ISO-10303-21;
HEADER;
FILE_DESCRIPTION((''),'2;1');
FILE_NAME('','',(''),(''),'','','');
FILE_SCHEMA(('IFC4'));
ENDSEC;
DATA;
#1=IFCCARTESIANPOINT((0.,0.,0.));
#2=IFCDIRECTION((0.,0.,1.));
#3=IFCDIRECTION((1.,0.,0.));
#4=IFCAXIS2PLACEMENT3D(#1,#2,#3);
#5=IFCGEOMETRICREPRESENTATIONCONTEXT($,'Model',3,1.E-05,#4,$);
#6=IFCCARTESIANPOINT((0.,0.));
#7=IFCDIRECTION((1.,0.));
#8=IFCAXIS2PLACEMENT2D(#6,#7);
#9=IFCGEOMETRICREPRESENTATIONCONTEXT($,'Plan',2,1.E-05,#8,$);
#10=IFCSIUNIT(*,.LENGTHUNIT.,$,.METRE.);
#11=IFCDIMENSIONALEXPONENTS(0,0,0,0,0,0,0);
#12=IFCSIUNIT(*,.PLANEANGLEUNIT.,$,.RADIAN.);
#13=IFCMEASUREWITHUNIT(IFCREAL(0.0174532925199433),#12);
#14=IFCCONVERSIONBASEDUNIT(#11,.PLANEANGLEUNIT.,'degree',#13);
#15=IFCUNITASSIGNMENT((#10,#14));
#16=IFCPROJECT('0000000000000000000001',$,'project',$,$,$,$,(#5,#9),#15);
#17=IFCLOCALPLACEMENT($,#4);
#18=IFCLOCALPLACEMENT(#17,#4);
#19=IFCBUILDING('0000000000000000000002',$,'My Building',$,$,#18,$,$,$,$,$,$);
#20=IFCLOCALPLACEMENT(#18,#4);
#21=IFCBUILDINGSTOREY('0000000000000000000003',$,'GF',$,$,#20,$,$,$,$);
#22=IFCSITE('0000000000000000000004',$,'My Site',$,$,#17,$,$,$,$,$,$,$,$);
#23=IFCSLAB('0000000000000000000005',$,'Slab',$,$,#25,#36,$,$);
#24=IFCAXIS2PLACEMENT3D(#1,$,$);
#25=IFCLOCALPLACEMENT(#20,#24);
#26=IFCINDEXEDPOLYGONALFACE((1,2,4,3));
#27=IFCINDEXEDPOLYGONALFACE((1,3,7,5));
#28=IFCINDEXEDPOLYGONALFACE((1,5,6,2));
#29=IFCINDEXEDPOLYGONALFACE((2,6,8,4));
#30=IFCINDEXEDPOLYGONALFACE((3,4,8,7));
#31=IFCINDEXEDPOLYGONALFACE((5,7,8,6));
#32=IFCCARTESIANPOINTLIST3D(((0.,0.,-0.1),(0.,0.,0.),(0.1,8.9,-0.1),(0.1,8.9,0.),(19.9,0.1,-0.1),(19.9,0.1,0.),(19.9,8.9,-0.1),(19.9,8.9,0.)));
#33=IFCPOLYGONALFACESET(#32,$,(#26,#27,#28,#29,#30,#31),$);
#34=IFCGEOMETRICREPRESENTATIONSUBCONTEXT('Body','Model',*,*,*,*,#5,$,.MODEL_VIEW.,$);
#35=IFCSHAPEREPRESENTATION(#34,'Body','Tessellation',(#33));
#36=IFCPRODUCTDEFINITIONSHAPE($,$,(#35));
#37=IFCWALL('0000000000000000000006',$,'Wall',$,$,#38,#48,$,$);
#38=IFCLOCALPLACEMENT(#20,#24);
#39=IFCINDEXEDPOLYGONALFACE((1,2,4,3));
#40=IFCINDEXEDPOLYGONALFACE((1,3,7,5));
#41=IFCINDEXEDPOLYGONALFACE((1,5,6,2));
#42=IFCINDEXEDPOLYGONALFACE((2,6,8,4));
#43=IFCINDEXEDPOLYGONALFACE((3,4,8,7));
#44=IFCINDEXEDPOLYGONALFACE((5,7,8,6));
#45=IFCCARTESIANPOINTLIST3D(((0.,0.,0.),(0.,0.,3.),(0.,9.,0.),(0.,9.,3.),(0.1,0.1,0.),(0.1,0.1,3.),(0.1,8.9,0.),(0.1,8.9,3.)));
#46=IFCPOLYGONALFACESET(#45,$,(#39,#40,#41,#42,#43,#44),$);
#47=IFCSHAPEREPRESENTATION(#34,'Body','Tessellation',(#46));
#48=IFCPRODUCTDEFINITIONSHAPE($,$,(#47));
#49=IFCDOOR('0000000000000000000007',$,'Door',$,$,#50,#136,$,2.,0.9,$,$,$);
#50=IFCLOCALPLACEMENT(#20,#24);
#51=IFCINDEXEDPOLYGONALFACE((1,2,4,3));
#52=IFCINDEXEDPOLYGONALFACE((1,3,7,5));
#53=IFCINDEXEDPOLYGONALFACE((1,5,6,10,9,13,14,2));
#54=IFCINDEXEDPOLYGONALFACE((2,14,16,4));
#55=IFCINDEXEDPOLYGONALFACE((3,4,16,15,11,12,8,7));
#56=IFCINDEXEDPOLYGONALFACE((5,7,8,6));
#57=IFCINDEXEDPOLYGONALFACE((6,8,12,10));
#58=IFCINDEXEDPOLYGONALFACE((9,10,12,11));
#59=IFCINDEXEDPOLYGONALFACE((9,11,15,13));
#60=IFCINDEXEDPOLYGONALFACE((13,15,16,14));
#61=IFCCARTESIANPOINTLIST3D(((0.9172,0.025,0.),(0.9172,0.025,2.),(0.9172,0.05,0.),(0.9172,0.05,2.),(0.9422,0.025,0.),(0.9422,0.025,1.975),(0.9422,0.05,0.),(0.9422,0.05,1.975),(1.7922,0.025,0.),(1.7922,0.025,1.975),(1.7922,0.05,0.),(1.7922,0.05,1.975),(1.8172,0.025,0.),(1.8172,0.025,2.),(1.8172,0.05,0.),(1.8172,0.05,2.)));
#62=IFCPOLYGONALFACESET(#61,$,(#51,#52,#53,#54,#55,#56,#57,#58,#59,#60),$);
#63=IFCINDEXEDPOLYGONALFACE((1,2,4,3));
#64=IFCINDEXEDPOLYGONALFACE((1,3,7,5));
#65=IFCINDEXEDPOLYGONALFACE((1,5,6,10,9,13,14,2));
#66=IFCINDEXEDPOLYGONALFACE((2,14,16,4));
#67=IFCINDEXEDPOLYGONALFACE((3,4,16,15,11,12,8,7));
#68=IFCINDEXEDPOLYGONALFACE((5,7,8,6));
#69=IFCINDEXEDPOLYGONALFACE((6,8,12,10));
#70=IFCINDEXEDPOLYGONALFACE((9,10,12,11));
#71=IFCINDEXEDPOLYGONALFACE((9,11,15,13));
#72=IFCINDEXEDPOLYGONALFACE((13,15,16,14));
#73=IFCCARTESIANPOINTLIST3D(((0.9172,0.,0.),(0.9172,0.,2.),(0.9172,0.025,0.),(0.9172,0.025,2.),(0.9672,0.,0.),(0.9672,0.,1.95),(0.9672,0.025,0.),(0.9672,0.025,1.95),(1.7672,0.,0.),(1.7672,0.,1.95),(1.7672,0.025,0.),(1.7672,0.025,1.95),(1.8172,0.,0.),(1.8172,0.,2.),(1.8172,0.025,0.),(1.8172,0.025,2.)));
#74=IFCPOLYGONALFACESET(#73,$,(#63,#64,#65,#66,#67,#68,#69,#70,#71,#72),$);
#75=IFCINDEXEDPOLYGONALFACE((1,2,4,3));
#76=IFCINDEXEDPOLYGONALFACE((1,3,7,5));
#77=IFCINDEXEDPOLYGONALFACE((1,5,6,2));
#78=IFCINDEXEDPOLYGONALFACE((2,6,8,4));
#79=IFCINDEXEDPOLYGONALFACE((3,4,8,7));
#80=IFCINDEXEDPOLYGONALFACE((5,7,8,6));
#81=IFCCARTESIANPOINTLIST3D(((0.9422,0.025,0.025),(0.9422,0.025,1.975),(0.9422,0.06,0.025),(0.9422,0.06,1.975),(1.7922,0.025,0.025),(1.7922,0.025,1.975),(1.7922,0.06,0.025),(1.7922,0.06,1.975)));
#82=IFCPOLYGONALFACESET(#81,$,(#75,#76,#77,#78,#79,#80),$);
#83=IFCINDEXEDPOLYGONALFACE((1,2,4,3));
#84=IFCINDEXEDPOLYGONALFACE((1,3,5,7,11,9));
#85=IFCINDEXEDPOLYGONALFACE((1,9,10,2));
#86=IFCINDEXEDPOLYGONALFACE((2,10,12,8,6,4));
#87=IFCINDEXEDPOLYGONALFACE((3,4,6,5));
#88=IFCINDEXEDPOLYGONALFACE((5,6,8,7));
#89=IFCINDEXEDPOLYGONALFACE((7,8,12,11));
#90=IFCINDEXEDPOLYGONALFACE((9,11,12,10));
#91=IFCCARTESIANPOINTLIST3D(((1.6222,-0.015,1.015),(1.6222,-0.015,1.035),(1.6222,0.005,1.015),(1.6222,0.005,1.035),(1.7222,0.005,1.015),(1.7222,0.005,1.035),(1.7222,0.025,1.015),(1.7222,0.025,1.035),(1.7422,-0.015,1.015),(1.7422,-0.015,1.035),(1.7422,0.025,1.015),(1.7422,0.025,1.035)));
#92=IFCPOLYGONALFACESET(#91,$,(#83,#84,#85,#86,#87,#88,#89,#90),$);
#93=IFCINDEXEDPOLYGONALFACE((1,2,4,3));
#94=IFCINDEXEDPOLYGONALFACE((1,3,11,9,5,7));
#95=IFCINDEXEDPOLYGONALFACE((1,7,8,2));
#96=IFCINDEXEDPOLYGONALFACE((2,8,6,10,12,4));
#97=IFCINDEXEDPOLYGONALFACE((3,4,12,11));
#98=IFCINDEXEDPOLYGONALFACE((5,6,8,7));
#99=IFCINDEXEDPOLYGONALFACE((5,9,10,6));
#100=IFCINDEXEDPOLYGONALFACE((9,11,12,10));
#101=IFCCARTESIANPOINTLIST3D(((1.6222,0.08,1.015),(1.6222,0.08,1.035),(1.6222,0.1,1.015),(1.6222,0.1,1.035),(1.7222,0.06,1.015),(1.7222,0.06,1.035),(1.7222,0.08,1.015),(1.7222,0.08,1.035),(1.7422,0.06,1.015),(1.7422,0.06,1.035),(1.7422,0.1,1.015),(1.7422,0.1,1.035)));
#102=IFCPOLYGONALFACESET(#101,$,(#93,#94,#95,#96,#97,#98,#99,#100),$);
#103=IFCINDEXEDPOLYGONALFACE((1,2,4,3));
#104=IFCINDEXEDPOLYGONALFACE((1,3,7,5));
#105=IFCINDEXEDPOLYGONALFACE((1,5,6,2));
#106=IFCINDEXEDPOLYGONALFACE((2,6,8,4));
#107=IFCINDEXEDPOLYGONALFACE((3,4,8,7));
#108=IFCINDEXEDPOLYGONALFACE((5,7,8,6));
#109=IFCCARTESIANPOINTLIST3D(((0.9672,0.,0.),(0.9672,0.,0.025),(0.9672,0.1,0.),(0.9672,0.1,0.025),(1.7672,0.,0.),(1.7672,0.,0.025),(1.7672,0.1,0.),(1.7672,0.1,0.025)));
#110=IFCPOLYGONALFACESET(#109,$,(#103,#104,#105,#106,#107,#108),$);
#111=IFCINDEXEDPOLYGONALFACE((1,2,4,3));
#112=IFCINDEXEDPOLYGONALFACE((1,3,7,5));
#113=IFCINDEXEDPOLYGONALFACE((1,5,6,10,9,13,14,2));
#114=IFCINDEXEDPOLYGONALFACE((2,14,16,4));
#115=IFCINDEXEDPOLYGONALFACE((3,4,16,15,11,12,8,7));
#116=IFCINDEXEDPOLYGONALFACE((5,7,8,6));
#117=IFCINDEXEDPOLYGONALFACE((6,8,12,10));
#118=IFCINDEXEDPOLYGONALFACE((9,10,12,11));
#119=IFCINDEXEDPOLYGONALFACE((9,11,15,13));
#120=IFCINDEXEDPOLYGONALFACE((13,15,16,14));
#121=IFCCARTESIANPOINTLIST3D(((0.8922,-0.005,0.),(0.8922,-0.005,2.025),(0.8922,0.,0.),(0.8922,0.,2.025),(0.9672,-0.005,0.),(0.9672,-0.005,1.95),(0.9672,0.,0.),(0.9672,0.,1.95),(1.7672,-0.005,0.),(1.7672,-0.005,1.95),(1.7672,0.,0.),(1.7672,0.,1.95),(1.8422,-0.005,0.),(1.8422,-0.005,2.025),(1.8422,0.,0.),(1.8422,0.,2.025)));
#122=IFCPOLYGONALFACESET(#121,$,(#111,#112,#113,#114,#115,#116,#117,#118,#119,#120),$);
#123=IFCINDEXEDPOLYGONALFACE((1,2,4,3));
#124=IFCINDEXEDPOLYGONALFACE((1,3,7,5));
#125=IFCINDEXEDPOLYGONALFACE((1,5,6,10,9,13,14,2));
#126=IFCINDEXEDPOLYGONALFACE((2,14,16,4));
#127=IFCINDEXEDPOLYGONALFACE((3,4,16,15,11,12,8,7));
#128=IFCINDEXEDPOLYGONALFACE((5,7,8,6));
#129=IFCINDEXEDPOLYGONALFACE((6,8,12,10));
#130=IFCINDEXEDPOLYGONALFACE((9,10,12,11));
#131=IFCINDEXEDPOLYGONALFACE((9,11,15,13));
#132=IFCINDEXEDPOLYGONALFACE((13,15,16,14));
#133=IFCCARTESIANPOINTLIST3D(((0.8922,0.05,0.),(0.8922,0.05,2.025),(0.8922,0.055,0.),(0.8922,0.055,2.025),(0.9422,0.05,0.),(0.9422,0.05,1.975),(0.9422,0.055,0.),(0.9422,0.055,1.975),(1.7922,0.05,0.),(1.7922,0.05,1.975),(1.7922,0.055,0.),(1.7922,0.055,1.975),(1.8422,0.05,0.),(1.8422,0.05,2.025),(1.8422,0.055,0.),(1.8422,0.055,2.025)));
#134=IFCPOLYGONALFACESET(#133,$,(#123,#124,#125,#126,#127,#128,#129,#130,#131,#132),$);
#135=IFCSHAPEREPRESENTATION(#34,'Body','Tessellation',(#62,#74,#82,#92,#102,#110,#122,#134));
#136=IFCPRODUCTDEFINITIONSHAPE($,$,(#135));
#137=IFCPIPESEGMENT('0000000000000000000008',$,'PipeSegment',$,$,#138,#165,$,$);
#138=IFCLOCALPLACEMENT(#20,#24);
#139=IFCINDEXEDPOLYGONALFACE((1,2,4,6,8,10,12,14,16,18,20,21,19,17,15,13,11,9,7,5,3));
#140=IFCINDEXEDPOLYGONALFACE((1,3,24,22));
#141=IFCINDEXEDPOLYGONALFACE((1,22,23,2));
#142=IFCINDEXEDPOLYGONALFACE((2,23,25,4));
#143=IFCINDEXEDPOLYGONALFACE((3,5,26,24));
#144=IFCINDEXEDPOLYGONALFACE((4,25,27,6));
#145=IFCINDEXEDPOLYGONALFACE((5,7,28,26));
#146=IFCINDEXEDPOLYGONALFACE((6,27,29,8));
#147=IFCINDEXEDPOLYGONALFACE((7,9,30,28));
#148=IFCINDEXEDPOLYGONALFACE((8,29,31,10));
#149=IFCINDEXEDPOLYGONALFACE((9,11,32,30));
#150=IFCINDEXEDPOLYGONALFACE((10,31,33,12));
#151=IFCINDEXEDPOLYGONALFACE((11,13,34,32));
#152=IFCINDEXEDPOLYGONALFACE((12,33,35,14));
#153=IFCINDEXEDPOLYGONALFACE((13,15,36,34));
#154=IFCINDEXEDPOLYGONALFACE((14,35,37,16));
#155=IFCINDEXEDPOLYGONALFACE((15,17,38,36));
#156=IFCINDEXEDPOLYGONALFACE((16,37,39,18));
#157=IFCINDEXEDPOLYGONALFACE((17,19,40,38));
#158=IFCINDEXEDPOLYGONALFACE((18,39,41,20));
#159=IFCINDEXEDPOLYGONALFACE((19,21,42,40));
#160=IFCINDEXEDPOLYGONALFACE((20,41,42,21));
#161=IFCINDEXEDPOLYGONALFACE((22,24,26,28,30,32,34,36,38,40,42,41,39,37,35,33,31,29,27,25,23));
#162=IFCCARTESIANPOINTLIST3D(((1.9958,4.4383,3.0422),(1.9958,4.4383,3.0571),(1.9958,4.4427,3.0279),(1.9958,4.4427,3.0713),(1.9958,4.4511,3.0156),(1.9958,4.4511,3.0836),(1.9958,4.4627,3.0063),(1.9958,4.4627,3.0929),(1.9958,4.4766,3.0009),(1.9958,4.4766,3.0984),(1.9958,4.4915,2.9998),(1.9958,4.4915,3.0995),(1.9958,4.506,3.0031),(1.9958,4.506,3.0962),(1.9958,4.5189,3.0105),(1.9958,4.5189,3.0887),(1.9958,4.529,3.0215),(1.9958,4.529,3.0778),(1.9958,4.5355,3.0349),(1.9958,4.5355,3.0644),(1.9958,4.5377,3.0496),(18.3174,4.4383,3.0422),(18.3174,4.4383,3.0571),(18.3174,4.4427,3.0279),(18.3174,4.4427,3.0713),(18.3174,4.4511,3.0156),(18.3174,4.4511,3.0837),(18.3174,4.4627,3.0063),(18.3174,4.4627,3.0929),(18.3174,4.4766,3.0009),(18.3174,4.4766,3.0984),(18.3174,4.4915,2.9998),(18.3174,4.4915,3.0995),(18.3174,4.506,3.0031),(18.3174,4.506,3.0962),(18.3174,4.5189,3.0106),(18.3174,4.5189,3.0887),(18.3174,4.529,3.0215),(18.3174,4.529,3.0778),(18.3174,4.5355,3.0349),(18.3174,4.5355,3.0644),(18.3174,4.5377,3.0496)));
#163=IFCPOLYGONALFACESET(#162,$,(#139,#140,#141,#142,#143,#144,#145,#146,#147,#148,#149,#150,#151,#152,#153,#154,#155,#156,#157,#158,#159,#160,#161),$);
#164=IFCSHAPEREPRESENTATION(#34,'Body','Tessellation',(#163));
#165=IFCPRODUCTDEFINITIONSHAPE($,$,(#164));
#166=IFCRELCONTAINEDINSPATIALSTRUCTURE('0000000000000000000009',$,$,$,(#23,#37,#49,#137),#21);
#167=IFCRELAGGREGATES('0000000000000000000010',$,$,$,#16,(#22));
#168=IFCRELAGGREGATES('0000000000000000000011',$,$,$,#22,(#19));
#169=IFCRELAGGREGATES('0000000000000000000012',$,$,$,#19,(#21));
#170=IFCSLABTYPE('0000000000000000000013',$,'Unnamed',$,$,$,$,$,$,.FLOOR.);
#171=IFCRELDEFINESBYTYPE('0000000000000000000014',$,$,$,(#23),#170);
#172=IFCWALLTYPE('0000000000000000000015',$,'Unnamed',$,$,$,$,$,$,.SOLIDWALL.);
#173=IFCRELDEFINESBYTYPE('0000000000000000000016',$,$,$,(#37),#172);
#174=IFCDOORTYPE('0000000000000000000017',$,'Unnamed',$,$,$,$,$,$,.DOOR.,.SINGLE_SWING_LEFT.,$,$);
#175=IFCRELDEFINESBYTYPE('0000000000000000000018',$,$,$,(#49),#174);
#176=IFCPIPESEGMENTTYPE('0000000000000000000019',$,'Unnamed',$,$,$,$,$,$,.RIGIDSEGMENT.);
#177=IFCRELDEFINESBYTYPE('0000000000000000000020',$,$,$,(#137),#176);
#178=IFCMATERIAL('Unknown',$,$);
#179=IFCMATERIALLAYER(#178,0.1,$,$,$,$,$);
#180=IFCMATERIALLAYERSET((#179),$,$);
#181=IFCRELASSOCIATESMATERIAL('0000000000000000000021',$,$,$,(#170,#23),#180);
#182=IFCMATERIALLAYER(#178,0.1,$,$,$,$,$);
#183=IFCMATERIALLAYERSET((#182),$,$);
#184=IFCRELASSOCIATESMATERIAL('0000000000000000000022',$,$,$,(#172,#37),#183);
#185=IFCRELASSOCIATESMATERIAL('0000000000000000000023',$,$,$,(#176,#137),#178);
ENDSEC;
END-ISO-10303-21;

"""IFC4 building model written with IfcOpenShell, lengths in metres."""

from ifc_helpers import new_model, entity, si_unit, converted_unit, frame, origin_with_axes, origin_2d_with_axis, place, context, subcontext, project, spatial, line, indexed_curve, circle, outline, extrude, shape, source, transform, mapped, material, layer, layer_set, layer_usage, material_profile, profile_set, profile_usage, type_object, type_shapes, element, save


model = new_model("IFC4")

# Units and contexts
model_context = context("Model", 3, precision=1e-05, world=origin_with_axes())
plan_context = context("Plan", 2, precision=1e-05, world=origin_2d_with_axis())
body_context_1 = subcontext(model_context, "Body", "Model", "MODEL_VIEW")
body_context_2 = subcontext(plan_context, "Body", "Plan", "PLAN_VIEW")
ifc_project = project(units=[si_unit("LENGTHUNIT", "METRE"), converted_unit("PLANEANGLEUNIT", "degree", entity("IfcReal", 0.0174532925199433), si_unit("PLANEANGLEUNIT", "RADIAN"), dimensions=[0, 0, 0, 0, 0, 0, 0])], contexts=[model_context, plan_context])

# Site, building, storey
site_placement = place(None, origin_with_axes())
site = spatial("IfcSite", under=ifc_project, at=site_placement, Name="My Site")
building_placement = place(site_placement, origin_with_axes())
building = spatial("IfcBuilding", under=site, at=building_placement, Name="My Building")
storey_placement = place(building_placement, origin_with_axes())
storey = spatial("IfcBuildingStorey", under=building, at=storey_placement, Name="GF")

# Slab
ifc_material = material(Name="Unknown")
ifc_layer_1 = layer(ifc_material, 0.1)
ifc_layer_set_1 = layer_set([ifc_layer_1])
ifc_layer_usage_1 = layer_usage(ifc_layer_set_1, "AXIS3", "POSITIVE", -0.1)
slab_type = type_object("IfcSlabType", Name="Unnamed", PredefinedType="FLOOR", material=ifc_layer_set_1)
slab_placement = place(storey_placement, frame((0.1, 8.9, 0.0), z_axis=(0.0, 0.0, 1.0), x_axis=(1.0, 0.0, 0.0)))
element("IfcSlab", 1, at=slab_placement, inside=storey, type_object=slab_type, material=ifc_layer_usage_1, Name="Slab", context=body_context_1, shape_type="SweptSolid", body=[
    extrude(outline(indexed_curve([(0.0, 0.0), (19.8, 0.0), (19.8, -8.8), (-0.1, -8.9), (0.0, 0.0)])), frame((0.0, 0.0, -0.1), z_axis=(0.0, 0.0, 1.0), x_axis=(1.0, 0.0, 0.0)), (0.0, 0.0, 1.0), 0.1),
])

# Shared definitions
ifc_layer_2 = layer(ifc_material, 0.1)
ifc_layer_set_2 = layer_set([ifc_layer_2])
wall_type = type_object("IfcWallType", Name="Unnamed", PredefinedType="SOLIDWALL", material=ifc_layer_set_2)
wall_1_placement = place(storey_placement, frame((0.0, 0.0, 0.0), z_axis=(0.0, 0.0, 1.0), x_axis=(1.0, 0.0, 0.0)))

# Wall
ifc_layer_usage_2 = layer_usage(ifc_layer_set_2, "AXIS2", "POSITIVE", 0.0)
wall_2_placement = place(storey_placement, frame((0.0, 9.0, 0.0), z_axis=(0.0, 0.0, 1.0), x_axis=(0.0, -1.0, 0.0)))
element("IfcWall", 2, at=wall_2_placement, inside=storey, type_object=wall_type, material=ifc_layer_usage_2, Name="Wall", context=body_context_1, shape_type="SweptSolid", body=[
    extrude(outline(indexed_curve([(0.0, 0.0), (0.1, 0.1), (8.9, 0.1), (9.0, 0.0)], segments=[line(1, 2, 3, 4, 1)])), origin_with_axes(), (0.0, 0.0, 1.0), 3.0),
])

# Door
door_type = type_object("IfcDoorType", Name="Unnamed", OperationType="SINGLE_SWING_LEFT", PredefinedType="DOOR")
shared_shape_1 = source(origin_with_axes(), body_context_1, "Body", "SweptSolid", [
    extrude(outline(indexed_curve([(0.0, 0.0), (0.0, 2.0), (0.9, 2.0), (0.9, 0.0), (0.875, 0.0), (0.875, 1.975), (0.025, 1.975), (0.025, 0.0)], segments=[line(1, 2, 3, 4, 5, 6, 7, 8, 1)])), frame((0.0, 0.025, 0.0), z_axis=(0.0, -1.0, 0.0), x_axis=(1.0, 0.0, 0.0)), (0.0, 0.0, -1.0), 0.025),
    extrude(outline(indexed_curve([(0.0, 0.0), (0.0, 2.0), (0.9, 2.0), (0.9, 0.0), (0.85, 0.0), (0.85, 1.95), (0.05, 1.95), (0.05, 0.0)], segments=[line(1, 2, 3, 4, 5, 6, 7, 8, 1)])), frame((0.0, 0.0, 0.0), z_axis=(0.0, -1.0, 0.0), x_axis=(1.0, 0.0, 0.0)), (0.0, 0.0, -1.0), 0.025),
    extrude(outline(indexed_curve([(0.0, 0.0), (0.85, 0.0), (0.85, 0.035), (0.0, 0.035)], segments=[line(1, 2, 3, 4, 1)])), frame((0.025, 0.025, 0.025), z_axis=(0.0, 0.0, 1.0), x_axis=(1.0, 0.0, 0.0)), (0.0, 0.0, 1.0), 1.95),
    extrude(outline(indexed_curve([(0.0, 0.0), (0.0, -0.04), (-0.12, -0.04), (-0.12, -0.02), (-0.02, -0.02), (-0.02, 0.0)], segments=[line(1, 2, 3, 4, 5, 6, 1)])), frame((0.825, 0.025, 1.015), z_axis=(0.0, 0.0, 1.0), x_axis=(1.0, 0.0, 0.0)), (0.0, 0.0, 1.0), 0.02),
    extrude(outline(indexed_curve([(0.0, 0.0), (0.0, 0.04), (-0.12, 0.04), (-0.12, 0.02), (-0.02, 0.02), (-0.02, 0.0)], segments=[line(1, 2, 3, 4, 5, 6, 1)])), frame((0.825, 0.06, 1.015), z_axis=(0.0, 0.0, 1.0), x_axis=(1.0, 0.0, 0.0)), (0.0, 0.0, 1.0), 0.02),
    extrude(outline(indexed_curve([(0.0, 0.0), (0.8, 0.0), (0.8, 0.1), (0.0, 0.1)], segments=[line(1, 2, 3, 4, 1)])), frame((0.05, 0.0, 0.0), z_axis=(0.0, 0.0, 1.0), x_axis=(1.0, 0.0, 0.0)), (0.0, 0.0, 1.0), 0.025),
    extrude(outline(indexed_curve([(0.0, 0.0), (0.0, 2.025), (0.95, 2.025), (0.95, 0.0), (0.875, 0.0), (0.875, 1.95), (0.075, 1.95), (0.075, 0.0)], segments=[line(1, 2, 3, 4, 5, 6, 7, 8, 1)])), frame((-0.025, -0.005, 0.0), z_axis=(0.0, -1.0, 0.0), x_axis=(1.0, 0.0, 0.0)), (0.0, 0.0, -1.0), 0.005),
    extrude(outline(indexed_curve([(0.0, 0.0), (0.0, 2.025), (0.95, 2.025), (0.95, 0.0), (0.9, 0.0), (0.9, 1.975), (0.05, 1.975), (0.05, 0.0)], segments=[line(1, 2, 3, 4, 5, 6, 7, 8, 1)])), frame((-0.025, 0.05, 0.0), z_axis=(0.0, -1.0, 0.0), x_axis=(1.0, 0.0, 0.0)), (0.0, 0.0, -1.0), 0.005),
])
shared_shape_2 = source(origin_with_axes(), body_context_2, "Body", "Curve2D", [
    entity("IfcIndexedPolyCurve", entity("IfcCartesianPointList2D", [[0.0, 0.0], [0.0, 0.05], [0.025, 0.05], [0.025, 0.025], [0.05, 0.025], [0.05, 0.0]]), [entity("IfcLineIndex", [1, 2, 3, 4, 5, 6, 1])]),
    entity("IfcIndexedPolyCurve", entity("IfcCartesianPointList2D", [[0.9, 0.0], [0.9, 0.05], [0.875, 0.05], [0.875, 0.025], [0.85, 0.025], [0.85, 0.0]]), [entity("IfcLineIndex", [1, 2, 3, 4, 5, 6, 1])]),
    entity("IfcTrimmedCurve", entity("IfcEllipse", entity("IfcAxis2Placement2D", entity("IfcCartesianPoint", [0.06, 0.05]), entity("IfcDirection", [1.0, 0.0])), 0.815, 0.85), [entity("IfcCartesianPoint", [0.875, 0.05])], [entity("IfcCartesianPoint", [0.06, 0.9])], True, "CARTESIAN"),
    entity("IfcIndexedPolyCurve", entity("IfcCartesianPointList2D", [[0.025, 0.05], [0.06, 0.05], [0.06, 0.9], [0.025, 0.9]]), [entity("IfcLineIndex", [1, 2, 3, 4, 1])]),
])
type_shapes(door_type, [shared_shape_1, shared_shape_2])
placement = place(wall_1_placement, frame((0.9172, 0.0, 0.0), z_axis=(0.0, 0.0, 1.0), x_axis=(1.0, 0.0, 0.0)))
door_placement = place(placement, origin_with_axes())
element("IfcDoor", 3, at=door_placement, inside=storey, type_object=door_type, Name="Door", OverallHeight=2.0, OverallWidth=0.9, shapes=[
    shape(body_context_1, "Body", "MappedRepresentation", [mapped(shared_shape_1, transform((0.0, 0.0, 0.0), x_axis=(1.0, 0.0, 0.0), y_axis=(0.0, 1.0, 0.0), z_axis=(0.0, 0.0, 1.0), scale=1.0))]),
    shape(body_context_2, "Body", "MappedRepresentation", [mapped(shared_shape_2, transform((0.0, 0.0, 0.0), x_axis=(1.0, 0.0, 0.0), y_axis=(0.0, 1.0, 0.0), z_axis=(0.0, 0.0, 1.0), scale=1.0))]),
])

# Pipe segment
ifc_material_profile = material_profile(ifc_material, circle(Radius=0.05))
ifc_profile_set = profile_set([ifc_material_profile])
ifc_profile_usage_1 = profile_usage(ifc_profile_set, cardinal=5)
pipe_segment_type = type_object("IfcPipeSegmentType", Name="Unnamed", PredefinedType="RIGIDSEGMENT", material=ifc_profile_set)
pipe_segment_1_placement = place(storey_placement, frame((1.9958, 4.4877, 3.0496), z_axis=(1.0, 0.0, 0.0), x_axis=(0.0, 1.0, 0.0)))
element("IfcPipeSegment", 4, at=pipe_segment_1_placement, inside=storey, type_object=pipe_segment_type, material=ifc_profile_usage_1, Name="PipeSegment", context=body_context_1, shape_type="SweptSolid", body=[
    extrude(circle(Radius=0.05), origin_with_axes(), (0.0, 0.0, 1.0), 16.3216),
])

save(model, "model.ifc")
